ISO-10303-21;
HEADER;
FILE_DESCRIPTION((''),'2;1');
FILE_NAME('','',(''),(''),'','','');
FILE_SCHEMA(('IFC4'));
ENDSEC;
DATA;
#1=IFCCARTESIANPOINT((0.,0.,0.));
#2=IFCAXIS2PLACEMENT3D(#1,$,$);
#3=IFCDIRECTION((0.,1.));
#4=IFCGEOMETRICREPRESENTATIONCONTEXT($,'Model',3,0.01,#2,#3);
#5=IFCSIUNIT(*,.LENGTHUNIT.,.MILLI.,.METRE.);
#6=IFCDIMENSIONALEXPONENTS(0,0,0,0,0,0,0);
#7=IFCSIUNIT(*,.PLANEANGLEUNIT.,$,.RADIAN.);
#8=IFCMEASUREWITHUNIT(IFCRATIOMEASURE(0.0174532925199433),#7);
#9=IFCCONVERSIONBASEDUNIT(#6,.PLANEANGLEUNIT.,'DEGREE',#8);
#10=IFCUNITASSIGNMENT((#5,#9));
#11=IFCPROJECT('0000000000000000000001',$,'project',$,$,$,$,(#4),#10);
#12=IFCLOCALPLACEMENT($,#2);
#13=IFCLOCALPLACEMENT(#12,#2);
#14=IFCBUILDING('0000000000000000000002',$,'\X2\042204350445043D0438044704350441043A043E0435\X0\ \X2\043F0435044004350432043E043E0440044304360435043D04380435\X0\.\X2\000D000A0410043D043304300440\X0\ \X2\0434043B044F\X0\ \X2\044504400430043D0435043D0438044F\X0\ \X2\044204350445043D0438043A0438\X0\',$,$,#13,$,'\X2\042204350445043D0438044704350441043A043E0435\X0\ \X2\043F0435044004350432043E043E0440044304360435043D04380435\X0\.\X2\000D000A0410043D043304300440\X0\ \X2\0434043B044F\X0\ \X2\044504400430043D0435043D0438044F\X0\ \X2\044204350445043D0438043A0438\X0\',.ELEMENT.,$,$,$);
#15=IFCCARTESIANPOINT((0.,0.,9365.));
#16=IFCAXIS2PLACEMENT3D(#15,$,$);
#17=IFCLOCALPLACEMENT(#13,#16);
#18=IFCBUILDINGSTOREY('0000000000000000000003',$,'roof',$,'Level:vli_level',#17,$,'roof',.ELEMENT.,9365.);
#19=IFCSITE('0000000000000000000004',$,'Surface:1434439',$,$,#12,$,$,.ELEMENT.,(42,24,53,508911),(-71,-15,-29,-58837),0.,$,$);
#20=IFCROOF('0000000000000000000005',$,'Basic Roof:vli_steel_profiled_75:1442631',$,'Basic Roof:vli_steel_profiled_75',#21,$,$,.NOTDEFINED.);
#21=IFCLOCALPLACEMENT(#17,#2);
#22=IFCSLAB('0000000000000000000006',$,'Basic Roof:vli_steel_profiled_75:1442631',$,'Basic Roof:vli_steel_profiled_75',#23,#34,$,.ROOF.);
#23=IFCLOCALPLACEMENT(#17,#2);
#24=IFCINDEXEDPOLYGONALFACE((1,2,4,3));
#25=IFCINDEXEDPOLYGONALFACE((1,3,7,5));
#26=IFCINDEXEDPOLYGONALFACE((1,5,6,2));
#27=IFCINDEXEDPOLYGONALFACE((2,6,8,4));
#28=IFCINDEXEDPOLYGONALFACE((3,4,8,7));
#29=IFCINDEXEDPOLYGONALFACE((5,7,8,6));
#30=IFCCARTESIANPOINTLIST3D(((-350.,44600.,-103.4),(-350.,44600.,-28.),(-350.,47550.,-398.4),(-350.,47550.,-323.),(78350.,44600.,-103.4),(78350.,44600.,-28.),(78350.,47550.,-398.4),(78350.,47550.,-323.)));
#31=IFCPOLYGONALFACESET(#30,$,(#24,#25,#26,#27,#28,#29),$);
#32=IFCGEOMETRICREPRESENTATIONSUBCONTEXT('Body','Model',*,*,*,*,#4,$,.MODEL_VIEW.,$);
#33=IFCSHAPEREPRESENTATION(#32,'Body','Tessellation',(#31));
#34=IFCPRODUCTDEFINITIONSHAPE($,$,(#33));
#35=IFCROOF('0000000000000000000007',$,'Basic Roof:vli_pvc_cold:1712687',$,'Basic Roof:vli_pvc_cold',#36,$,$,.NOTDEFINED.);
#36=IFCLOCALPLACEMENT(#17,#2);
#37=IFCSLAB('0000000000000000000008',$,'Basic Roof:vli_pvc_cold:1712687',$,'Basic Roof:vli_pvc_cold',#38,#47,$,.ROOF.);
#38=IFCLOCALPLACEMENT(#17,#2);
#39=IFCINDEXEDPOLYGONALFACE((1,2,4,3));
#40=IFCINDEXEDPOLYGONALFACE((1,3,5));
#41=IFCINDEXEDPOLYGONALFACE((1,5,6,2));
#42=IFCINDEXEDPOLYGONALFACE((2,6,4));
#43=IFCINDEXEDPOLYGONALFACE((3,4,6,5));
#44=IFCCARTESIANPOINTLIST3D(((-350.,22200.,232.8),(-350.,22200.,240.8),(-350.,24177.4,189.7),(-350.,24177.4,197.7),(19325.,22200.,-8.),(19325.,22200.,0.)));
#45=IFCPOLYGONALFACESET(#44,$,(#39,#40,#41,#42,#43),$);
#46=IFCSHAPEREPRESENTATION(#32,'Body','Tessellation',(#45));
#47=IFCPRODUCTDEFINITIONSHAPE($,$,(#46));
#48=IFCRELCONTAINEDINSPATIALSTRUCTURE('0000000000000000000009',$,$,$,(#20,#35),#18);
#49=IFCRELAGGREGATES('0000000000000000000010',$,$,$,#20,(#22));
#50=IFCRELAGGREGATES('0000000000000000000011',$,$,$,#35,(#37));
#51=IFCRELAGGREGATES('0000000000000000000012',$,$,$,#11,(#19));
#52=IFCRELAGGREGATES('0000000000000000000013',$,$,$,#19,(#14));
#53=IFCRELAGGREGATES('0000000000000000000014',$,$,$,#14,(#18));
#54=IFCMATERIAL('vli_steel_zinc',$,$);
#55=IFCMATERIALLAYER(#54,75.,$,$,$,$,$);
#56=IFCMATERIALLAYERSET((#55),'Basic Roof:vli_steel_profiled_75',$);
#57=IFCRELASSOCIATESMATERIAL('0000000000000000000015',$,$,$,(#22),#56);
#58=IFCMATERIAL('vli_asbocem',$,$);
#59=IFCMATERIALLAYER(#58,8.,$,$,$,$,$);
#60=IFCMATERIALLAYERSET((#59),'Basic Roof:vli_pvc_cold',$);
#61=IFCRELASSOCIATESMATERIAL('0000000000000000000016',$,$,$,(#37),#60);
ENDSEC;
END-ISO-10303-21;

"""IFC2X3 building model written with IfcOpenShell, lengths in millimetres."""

from ifc_helpers import new_model, entity, si_unit, converted_unit, direction, frame, frame_2d, origin, place, context, subcontext, project, spatial, polyline, rectangle, outline, extrude, material, layer, layer_set, element, aggregate, save


model = new_model("IFC2X3")

# Units and contexts
model_context = context("Model", 3, precision=0.01, world=origin(), true_north=direction((0.0, 1.0)))
body_context = subcontext(model_context, "Body", "Model", "MODEL_VIEW")
ifc_project = project(units=[si_unit("LENGTHUNIT", "METRE", prefix="MILLI"), converted_unit("PLANEANGLEUNIT", "DEGREE", entity("IfcRatioMeasure", 0.0174532925199433), si_unit("PLANEANGLEUNIT", "RADIAN"), dimensions=[0, 0, 0, 0, 0, 0, 0])], contexts=[model_context])

# Site, building, storey
site_placement = place(None, origin())
site = spatial("IfcSite", under=ifc_project, at=site_placement, Name="Surface:1434439", CompositionType="ELEMENT", RefLatitude=(42, 24, 53, 508911), RefLongitude=(-71, -15, -29, -58837), RefElevation=0.0)
building_placement = place(site_placement, origin())
building = spatial("IfcBuilding", under=site, at=building_placement, Name="Техническое перевооружение.\r\nАнгар для хранения техники", LongName="Техническое перевооружение.\r\nАнгар для хранения техники", CompositionType="ELEMENT")
storey_placement = place(building_placement, frame((0.0, 0.0, 9365.0)))
storey = spatial("IfcBuildingStorey", under=building, at=storey_placement, Name="roof", ObjectType="Level:vli_level", LongName="roof", CompositionType="ELEMENT", Elevation=9365.0)

# Roof, slab
roof_1_placement = place(storey_placement, frame((-350.0, 44600.0, -398.4)))
roof_1 = element("IfcRoof", 1, at=roof_1_placement, inside=storey, Name="Basic Roof:vli_steel_profiled_75:1442631", ObjectType="Basic Roof:vli_steel_profiled_75", ShapeType="NOTDEFINED")
ifc_material_1 = material(Name="vli_steel_zinc")
ifc_layer_1 = layer(ifc_material_1, 75.0)
ifc_layer_set_1 = layer_set([ifc_layer_1], Name="Basic Roof:vli_steel_profiled_75")
slab_1_placement = place(roof_1_placement, origin())
slab_1 = element("IfcSlab", 2, at=slab_1_placement, material=ifc_layer_set_1, Name="Basic Roof:vli_steel_profiled_75:1442631", ObjectType="Basic Roof:vli_steel_profiled_75", PredefinedType="ROOF", context=body_context, shape_type="SweptSolid", body=[
    extrude(rectangle(XDim=78700.0, YDim=2964.7, at=frame_2d((0.0, 0.0), x_axis=(-1.0, 0.0))), frame((39350.0, 1475.0, 147.5), z_axis=(0.0, 0.099504, 0.995037), x_axis=(1.0, 0.0, 0.0)), (0.0, -0.099504, 0.995037), 75.4),
])
aggregate(roof_1, [slab_1])

# Roof, slab
roof_2_placement = place(storey_placement, frame((-350.0, 20222.6, -8.0)))
roof_2 = element("IfcRoof", 3, at=roof_2_placement, inside=storey, Name="Basic Roof:vli_pvc_cold:1712687", ObjectType="Basic Roof:vli_pvc_cold", ShapeType="NOTDEFINED")
ifc_material_2 = material(Name="vli_asbocem")
ifc_layer_2 = layer(ifc_material_2, 8.0)
ifc_layer_set_2 = layer_set([ifc_layer_2], Name="Basic Roof:vli_pvc_cold")
slab_2_placement = place(roof_2_placement, origin())
slab_2 = element("IfcSlab", 4, at=slab_2_placement, material=ifc_layer_set_2, Name="Basic Roof:vli_pvc_cold:1712687", ObjectType="Basic Roof:vli_pvc_cold", PredefinedType="ROOF", context=body_context, shape_type="SweptSolid", body=[
    extrude(outline(polyline([(-9838.2, 988.9), (-9838.2, -988.9), (9838.2, -983.7), (-9838.2, 988.9)])), frame((9837.5, 2963.5, 98.9), z_axis=(0.012237, 0.021791, 0.999688), x_axis=(0.999925, -0.000267, -0.012234)), (-0.012234, -0.021793, 0.999688), 8.0),
])
aggregate(roof_2, [slab_2])

save(model, "model.ifc")
